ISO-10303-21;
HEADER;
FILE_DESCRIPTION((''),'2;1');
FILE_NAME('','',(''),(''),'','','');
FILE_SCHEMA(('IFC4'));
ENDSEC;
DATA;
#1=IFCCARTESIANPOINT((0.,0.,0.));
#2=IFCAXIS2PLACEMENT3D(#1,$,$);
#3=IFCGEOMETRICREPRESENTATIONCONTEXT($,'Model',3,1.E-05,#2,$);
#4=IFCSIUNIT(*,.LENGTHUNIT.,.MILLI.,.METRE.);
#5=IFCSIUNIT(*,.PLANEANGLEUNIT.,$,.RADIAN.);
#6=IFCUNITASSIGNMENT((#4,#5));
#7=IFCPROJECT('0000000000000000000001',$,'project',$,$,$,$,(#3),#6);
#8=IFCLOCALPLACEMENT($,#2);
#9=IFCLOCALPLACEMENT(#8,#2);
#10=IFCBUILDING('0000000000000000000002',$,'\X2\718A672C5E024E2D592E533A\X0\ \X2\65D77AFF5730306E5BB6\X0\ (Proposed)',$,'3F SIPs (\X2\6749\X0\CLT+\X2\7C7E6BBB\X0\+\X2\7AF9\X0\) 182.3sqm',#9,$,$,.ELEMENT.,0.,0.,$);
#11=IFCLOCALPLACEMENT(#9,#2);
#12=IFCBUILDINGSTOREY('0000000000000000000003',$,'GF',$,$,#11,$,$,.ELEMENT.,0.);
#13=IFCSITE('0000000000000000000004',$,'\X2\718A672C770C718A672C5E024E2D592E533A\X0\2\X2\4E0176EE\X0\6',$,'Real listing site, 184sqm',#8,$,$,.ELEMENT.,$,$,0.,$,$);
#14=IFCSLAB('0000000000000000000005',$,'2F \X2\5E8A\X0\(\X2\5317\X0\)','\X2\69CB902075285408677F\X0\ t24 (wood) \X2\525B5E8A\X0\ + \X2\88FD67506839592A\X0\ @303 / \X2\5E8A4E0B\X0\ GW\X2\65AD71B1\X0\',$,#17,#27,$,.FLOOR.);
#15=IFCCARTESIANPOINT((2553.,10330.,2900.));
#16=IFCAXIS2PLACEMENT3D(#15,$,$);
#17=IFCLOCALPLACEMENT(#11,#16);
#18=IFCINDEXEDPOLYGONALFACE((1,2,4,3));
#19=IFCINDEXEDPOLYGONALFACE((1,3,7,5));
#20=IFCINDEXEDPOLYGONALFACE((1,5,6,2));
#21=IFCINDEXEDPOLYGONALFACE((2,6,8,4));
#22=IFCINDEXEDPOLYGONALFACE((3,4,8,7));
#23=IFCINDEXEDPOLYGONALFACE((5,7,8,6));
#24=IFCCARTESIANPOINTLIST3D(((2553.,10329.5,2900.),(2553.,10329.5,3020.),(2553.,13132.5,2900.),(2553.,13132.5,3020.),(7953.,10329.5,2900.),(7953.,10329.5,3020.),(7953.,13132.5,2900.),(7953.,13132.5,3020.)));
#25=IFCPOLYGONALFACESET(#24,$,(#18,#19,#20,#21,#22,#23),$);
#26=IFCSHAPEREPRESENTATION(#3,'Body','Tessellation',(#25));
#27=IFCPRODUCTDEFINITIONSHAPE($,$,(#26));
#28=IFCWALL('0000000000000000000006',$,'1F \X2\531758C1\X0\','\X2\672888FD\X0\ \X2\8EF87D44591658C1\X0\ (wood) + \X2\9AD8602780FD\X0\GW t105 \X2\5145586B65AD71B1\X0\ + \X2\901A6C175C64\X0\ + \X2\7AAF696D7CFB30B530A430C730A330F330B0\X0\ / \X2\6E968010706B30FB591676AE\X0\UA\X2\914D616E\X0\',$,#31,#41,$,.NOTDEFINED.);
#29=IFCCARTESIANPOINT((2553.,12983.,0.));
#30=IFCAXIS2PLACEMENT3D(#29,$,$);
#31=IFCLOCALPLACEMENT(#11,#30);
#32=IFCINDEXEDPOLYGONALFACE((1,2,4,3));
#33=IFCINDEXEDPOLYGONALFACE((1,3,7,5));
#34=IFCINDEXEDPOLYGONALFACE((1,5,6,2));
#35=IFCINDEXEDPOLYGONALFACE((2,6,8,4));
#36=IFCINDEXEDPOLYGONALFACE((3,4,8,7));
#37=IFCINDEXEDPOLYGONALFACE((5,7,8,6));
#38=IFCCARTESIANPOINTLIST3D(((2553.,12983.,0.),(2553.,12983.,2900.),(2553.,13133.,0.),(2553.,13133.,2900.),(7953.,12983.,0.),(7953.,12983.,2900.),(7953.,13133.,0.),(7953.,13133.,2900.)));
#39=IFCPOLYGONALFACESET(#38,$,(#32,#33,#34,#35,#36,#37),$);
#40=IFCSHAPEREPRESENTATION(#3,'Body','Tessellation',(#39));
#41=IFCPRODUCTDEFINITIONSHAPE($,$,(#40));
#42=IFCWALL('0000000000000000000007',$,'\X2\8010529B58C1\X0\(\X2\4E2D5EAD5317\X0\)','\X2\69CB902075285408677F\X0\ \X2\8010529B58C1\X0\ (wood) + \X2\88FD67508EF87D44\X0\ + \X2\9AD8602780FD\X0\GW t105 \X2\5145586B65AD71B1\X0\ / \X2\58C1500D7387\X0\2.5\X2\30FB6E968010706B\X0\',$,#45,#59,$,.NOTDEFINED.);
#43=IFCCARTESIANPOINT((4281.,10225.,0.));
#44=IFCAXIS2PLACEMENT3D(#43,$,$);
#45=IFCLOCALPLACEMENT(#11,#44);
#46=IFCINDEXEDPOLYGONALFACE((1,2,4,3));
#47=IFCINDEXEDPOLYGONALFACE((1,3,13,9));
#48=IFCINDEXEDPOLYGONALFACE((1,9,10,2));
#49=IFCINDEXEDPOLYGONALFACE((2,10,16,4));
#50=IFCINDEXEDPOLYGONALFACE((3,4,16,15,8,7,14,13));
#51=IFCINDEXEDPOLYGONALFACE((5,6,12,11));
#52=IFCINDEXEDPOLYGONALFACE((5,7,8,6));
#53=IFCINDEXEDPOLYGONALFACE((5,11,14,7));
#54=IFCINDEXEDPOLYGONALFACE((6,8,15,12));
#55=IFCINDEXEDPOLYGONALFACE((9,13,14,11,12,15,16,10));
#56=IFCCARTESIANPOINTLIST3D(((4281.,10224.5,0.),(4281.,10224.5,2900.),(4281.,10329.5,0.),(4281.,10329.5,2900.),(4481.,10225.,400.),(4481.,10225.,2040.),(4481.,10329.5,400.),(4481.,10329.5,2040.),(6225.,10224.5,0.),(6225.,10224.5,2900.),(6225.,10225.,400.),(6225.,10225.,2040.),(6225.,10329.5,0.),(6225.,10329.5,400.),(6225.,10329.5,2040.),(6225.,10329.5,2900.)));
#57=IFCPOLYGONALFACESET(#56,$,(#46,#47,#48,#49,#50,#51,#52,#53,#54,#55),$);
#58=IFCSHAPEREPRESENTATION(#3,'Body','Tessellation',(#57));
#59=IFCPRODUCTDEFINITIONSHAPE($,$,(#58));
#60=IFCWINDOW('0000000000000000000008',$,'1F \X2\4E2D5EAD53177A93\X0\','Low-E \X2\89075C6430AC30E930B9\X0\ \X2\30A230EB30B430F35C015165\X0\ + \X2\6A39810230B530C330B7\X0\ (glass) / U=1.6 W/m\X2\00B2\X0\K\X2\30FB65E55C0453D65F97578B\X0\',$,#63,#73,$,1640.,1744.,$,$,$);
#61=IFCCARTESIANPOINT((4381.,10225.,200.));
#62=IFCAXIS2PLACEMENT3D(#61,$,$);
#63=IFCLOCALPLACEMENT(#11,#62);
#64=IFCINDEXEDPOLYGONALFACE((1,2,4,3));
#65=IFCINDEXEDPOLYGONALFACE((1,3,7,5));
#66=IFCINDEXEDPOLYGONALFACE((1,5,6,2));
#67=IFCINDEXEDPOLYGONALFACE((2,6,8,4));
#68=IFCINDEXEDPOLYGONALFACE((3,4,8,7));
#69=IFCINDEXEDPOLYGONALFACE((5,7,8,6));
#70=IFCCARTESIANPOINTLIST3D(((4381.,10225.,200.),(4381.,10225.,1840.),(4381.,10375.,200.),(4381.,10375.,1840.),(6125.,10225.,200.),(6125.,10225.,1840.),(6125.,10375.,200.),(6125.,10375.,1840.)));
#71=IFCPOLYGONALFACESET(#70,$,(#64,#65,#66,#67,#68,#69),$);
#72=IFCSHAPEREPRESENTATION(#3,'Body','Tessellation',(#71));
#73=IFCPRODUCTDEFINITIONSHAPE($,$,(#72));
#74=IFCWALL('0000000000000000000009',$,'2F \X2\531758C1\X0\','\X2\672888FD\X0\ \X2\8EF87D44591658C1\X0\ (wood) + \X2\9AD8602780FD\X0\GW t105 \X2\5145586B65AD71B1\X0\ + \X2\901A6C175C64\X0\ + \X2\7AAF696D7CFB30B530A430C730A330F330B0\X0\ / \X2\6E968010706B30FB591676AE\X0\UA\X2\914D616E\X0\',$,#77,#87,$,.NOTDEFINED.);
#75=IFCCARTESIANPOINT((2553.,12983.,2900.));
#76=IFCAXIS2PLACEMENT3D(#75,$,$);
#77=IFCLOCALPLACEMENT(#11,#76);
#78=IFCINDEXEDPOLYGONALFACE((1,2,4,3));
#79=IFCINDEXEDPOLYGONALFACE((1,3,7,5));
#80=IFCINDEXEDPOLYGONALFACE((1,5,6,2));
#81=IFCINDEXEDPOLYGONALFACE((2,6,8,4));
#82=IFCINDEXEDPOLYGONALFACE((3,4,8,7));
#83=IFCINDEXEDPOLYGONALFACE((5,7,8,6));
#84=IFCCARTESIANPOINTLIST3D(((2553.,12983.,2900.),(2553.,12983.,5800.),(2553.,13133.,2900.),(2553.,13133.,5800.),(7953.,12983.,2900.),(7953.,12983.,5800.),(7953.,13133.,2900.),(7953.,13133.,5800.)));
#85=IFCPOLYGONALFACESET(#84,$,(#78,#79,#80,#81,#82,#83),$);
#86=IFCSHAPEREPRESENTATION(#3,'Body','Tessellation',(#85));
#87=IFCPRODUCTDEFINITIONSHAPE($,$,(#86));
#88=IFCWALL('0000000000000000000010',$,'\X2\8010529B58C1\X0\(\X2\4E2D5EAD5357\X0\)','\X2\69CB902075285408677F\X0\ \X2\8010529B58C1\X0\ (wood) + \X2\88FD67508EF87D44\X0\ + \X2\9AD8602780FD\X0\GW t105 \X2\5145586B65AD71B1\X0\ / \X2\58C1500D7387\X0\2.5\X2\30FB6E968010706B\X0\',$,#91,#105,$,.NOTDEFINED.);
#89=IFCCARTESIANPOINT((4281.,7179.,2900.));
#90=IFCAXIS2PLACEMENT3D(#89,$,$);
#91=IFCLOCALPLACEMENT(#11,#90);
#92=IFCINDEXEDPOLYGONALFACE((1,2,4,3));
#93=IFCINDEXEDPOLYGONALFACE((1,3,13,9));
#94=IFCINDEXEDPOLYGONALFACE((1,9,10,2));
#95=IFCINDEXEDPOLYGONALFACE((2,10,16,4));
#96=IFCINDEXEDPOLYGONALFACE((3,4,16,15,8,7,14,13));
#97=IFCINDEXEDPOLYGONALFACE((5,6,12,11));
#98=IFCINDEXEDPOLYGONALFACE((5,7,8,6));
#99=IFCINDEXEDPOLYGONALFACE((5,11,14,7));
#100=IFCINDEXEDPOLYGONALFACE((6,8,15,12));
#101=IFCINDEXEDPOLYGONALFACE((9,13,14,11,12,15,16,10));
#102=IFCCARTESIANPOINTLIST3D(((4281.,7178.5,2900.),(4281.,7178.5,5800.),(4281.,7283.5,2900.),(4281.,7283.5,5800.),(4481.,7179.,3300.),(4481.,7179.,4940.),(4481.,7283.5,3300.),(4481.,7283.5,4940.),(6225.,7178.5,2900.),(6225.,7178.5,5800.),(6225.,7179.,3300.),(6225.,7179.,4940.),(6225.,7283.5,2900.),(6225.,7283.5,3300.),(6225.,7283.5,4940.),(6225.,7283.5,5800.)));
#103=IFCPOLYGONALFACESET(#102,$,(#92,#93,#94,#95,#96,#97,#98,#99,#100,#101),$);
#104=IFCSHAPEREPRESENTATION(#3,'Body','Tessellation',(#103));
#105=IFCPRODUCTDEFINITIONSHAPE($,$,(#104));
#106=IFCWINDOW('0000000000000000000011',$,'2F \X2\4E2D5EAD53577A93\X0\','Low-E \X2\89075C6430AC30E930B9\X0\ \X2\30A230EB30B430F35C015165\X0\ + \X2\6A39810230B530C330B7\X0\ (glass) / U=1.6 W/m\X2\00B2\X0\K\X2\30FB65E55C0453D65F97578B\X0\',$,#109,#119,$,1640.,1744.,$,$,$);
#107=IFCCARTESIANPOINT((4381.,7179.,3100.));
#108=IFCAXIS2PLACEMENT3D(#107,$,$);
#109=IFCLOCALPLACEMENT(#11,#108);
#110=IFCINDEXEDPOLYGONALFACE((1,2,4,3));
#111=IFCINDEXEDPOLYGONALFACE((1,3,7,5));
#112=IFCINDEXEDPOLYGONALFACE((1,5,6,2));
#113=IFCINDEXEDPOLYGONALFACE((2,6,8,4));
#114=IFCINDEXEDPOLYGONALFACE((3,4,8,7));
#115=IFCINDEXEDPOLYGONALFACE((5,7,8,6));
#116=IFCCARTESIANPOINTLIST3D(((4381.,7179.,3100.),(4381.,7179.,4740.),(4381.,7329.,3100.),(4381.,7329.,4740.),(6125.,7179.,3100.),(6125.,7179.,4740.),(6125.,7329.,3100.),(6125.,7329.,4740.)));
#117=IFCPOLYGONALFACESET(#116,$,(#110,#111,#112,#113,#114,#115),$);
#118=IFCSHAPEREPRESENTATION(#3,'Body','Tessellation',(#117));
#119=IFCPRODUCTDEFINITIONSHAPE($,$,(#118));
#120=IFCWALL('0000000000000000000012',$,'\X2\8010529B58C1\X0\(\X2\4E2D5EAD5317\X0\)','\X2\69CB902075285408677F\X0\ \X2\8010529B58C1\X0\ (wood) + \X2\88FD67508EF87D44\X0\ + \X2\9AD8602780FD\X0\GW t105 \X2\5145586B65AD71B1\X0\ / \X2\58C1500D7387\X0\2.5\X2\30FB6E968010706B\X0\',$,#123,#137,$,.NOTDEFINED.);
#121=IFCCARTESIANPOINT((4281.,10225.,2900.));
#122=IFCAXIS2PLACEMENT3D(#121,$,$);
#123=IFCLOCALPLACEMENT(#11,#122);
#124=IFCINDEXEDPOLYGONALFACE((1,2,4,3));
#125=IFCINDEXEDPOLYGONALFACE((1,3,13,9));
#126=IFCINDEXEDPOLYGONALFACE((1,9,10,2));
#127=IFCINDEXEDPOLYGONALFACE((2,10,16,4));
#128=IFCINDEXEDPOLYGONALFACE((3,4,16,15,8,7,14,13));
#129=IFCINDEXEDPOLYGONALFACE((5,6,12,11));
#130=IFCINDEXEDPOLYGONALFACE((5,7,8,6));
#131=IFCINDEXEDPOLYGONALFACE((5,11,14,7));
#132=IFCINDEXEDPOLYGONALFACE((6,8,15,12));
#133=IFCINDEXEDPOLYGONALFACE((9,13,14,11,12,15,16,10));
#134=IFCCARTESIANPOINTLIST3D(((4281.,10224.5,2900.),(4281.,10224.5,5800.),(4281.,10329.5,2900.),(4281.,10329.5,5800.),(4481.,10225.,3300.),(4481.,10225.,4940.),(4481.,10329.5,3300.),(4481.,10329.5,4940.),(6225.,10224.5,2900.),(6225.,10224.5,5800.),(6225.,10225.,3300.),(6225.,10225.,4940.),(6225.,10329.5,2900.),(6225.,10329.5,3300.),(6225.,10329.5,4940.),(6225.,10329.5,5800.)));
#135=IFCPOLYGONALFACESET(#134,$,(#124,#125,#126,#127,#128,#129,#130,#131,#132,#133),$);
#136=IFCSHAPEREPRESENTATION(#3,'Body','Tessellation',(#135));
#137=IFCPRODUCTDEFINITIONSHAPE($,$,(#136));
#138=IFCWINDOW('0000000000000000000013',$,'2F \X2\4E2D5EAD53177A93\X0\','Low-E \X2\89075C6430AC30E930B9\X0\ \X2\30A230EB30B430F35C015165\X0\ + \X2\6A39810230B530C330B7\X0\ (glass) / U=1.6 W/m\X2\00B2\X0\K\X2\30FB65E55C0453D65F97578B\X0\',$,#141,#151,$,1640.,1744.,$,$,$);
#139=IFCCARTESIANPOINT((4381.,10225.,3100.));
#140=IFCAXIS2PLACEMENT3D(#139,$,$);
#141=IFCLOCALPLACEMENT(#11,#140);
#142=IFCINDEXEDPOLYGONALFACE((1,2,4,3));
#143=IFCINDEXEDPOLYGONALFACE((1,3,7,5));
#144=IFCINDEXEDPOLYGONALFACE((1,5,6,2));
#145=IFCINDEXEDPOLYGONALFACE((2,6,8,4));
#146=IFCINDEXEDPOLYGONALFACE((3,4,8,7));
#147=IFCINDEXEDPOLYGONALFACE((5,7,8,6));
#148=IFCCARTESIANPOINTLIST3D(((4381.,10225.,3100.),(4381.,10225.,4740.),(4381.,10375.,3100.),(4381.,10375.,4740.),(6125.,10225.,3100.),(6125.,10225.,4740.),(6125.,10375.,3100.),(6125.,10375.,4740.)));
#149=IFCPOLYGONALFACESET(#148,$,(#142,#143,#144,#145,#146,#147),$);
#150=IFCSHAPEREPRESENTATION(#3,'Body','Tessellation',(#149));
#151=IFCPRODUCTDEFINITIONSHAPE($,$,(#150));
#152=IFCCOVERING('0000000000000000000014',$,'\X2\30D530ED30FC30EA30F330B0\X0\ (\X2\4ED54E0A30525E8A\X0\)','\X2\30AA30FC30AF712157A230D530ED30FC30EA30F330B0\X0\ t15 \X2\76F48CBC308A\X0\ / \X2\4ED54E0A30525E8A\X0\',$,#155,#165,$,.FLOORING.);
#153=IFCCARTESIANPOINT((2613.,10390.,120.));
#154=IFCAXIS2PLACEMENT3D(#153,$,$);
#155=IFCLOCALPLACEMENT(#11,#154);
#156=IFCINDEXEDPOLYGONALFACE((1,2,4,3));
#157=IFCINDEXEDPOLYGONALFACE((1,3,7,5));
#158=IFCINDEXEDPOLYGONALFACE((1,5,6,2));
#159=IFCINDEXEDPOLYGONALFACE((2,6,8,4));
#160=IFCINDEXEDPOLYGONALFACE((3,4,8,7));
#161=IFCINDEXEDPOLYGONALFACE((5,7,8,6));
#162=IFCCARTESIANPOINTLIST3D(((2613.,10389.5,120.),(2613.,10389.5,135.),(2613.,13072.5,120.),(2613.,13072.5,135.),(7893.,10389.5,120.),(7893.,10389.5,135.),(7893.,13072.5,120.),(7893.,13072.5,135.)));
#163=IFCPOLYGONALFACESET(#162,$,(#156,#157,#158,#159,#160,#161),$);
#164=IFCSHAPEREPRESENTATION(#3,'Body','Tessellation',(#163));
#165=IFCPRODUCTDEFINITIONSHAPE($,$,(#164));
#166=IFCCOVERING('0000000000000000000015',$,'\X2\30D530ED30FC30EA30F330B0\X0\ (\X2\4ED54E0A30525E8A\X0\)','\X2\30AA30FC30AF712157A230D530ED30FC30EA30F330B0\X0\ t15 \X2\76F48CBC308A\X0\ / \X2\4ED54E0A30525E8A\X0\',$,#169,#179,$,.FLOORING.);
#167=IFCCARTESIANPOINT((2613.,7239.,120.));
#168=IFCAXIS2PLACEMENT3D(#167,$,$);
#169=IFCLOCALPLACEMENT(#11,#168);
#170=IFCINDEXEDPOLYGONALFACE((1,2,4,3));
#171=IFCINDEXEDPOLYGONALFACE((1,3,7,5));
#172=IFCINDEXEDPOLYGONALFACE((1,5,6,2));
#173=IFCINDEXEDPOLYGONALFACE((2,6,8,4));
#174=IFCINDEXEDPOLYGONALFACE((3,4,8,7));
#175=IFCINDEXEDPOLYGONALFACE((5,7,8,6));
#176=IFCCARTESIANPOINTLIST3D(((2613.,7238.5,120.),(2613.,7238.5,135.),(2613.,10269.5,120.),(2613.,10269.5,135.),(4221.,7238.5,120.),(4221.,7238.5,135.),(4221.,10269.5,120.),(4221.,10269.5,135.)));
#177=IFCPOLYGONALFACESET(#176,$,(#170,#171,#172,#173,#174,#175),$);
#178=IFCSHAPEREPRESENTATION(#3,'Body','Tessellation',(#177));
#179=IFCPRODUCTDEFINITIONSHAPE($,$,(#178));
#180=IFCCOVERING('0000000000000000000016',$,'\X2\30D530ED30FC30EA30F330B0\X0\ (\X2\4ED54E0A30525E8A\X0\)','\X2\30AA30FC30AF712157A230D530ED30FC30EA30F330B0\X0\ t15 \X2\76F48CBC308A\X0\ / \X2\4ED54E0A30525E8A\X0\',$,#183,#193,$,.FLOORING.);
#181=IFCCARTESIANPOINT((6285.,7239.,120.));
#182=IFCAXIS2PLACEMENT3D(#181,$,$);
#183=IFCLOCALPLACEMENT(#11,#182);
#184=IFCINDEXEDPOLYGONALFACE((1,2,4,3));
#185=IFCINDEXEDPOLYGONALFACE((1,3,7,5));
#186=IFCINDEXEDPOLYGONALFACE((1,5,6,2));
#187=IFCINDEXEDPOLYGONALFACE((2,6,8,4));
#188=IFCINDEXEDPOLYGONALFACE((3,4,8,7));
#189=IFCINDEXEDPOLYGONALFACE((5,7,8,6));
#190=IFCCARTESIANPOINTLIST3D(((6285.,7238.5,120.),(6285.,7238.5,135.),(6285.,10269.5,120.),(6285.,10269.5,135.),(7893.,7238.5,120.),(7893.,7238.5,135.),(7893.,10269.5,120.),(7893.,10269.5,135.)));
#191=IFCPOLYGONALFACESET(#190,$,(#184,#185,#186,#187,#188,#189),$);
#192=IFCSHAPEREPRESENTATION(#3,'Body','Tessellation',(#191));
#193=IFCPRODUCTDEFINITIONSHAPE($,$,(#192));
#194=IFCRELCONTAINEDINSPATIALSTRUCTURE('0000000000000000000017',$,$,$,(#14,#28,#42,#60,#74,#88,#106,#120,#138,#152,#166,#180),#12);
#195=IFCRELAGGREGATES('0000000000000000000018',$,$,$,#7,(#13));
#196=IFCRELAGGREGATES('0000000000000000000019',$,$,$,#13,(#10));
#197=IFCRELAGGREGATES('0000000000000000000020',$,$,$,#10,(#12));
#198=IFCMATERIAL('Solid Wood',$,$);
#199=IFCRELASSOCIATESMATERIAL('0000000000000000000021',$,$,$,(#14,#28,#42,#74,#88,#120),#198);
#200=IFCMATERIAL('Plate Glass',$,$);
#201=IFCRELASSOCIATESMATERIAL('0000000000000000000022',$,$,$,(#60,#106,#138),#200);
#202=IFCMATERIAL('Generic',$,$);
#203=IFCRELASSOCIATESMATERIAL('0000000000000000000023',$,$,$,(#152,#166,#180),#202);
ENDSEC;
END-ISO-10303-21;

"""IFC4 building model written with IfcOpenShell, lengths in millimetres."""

from ifc_helpers import new_model, si_unit, frame, frame_2d, origin, place, context, project, spatial, rectangle, extrude, material, element, fill, save


model = new_model("IFC4")

# Units and contexts
model_context = context("Model", 3, precision=1e-05, world=origin())
ifc_project = project(units=[si_unit("LENGTHUNIT", "METRE", prefix="MILLI"), si_unit("PLANEANGLEUNIT", "RADIAN")], contexts=[model_context])

# Site, building, storey
site_placement = place(None, origin())
site = spatial("IfcSite", under=ifc_project, at=site_placement, Name="熊本県熊本市中央区2丁目6", ObjectType="Real listing site, 184sqm", CompositionType="ELEMENT", RefElevation=0.0)
building_placement = place(site_placement, origin())
building = spatial("IfcBuilding", under=site, at=building_placement, Name="熊本市中央区 旗竿地の家 (Proposed)", ObjectType="3F SIPs (杉CLT+籾殻+竹) 182.3sqm", CompositionType="ELEMENT", ElevationOfRefHeight=0.0, ElevationOfTerrain=0.0)
storey_placement = place(building_placement, origin())
storey = spatial("IfcBuildingStorey", under=building, at=storey_placement, Name="GF", CompositionType="ELEMENT", Elevation=0.0)

# Slab
ifc_material_1 = material(Name="Solid Wood")
slab_1_placement = place(storey_placement, frame((2553.0, 10330.0, 2900.0)))
element("IfcSlab", 1, at=slab_1_placement, inside=storey, material=ifc_material_1, Name="2F 床(北)", Description="構造用合板 t24 (wood) 剛床 + 製材根太 @303 / 床下 GW断熱", PredefinedType="FLOOR", context=model_context, shape_type="SweptSolid", body=[
    extrude(rectangle(XDim=5400.0, YDim=2803.0, at=frame_2d((2700.0, 1401.0))), frame((2553.0, 10330.0, 2900.0)), (0.0, 0.0, 1.0), 120.0),
])

# Wall
wall_1_placement = place(storey_placement, frame((2553.0, 12983.0, 0.0)))
element("IfcWall", 2, at=wall_1_placement, inside=storey, material=ifc_material_1, Name="1F 北壁", Description="木製 軸組外壁 (wood) + 高性能GW t105 充填断熱 + 通気層 + 窯業系サイディング / 準耐火・外皮UA配慮", PredefinedType="NOTDEFINED", context=model_context, shape_type="SweptSolid", body=[
    extrude(rectangle(XDim=5400.0, YDim=150.0, at=frame_2d((2700.0, 75.0))), frame((2553.0, 12983.0, 0.0)), (0.0, 0.0, 1.0), 2900.0),
])

# Wall, opening, window
wall_2_placement = place(storey_placement, frame((4281.0, 10225.0, 0.0)))
wall_2 = element("IfcWall", 3, at=wall_2_placement, inside=storey, material=ifc_material_1, Name="耐力壁(中庭北)", Description="構造用合板 耐力壁 (wood) + 製材軸組 + 高性能GW t105 充填断熱 / 壁倍率2.5・準耐火", PredefinedType="NOTDEFINED", context=model_context, shape_type="SweptSolid", body=[
    extrude(rectangle(XDim=1944.0, YDim=105.0, at=frame_2d((972.0, 52.0))), frame((4281.0, 10225.0, 0.0)), (0.0, 0.0, 1.0), 2900.0),
])
opening_1_placement = place(storey_placement, frame((4381.0, 10225.0, 200.0)))
opening_1 = element("IfcOpeningElement", 4, at=opening_1_placement, cuts=wall_2, PredefinedType="NOTDEFINED", context=model_context, shape_type="SweptSolid", body=[
    extrude(rectangle(XDim=1744.0, YDim=150.0, at=frame_2d((872.0, 75.0))), frame((4381.0, 10225.0, 200.0)), (0.0, 0.0, 1.0), 1640.0),
])
ifc_material_2 = material(Name="Plate Glass")
window_1_placement = place(storey_placement, frame((4381.0, 10225.0, 200.0)))
window_1 = element("IfcWindow", 5, at=window_1_placement, inside=storey, material=ifc_material_2, Name="1F 中庭北窓", Description="Low-E 複層ガラス アルゴン封入 + 樹脂サッシ (glass) / U=1.6 W/m²K・日射取得型", OverallHeight=1640.0, OverallWidth=1744.0, context=model_context, shape_type="SweptSolid", body=[
    extrude(rectangle(XDim=1744.0, YDim=150.0, at=frame_2d((872.0, 75.0))), frame((4381.0, 10225.0, 200.0)), (0.0, 0.0, 1.0), 1640.0),
])
fill(opening_1, window_1)

# Wall
wall_3_placement = place(storey_placement, frame((2553.0, 12983.0, 2900.0)))
element("IfcWall", 6, at=wall_3_placement, inside=storey, material=ifc_material_1, Name="2F 北壁", Description="木製 軸組外壁 (wood) + 高性能GW t105 充填断熱 + 通気層 + 窯業系サイディング / 準耐火・外皮UA配慮", PredefinedType="NOTDEFINED", context=model_context, shape_type="SweptSolid", body=[
    extrude(rectangle(XDim=5400.0, YDim=150.0, at=frame_2d((2700.0, 75.0))), frame((2553.0, 12983.0, 2900.0)), (0.0, 0.0, 1.0), 2900.0),
])

# Walls, openings, windows
wall_4_placement = place(storey_placement, frame((4281.0, 7179.0, 2900.0)))
wall_4 = element("IfcWall", 7, at=wall_4_placement, inside=storey, material=ifc_material_1, Name="耐力壁(中庭南)", Description="構造用合板 耐力壁 (wood) + 製材軸組 + 高性能GW t105 充填断熱 / 壁倍率2.5・準耐火", PredefinedType="NOTDEFINED", context=model_context, shape_type="SweptSolid", body=[
    extrude(rectangle(XDim=1944.0, YDim=105.0, at=frame_2d((972.0, 52.0))), frame((4281.0, 7179.0, 2900.0)), (0.0, 0.0, 1.0), 2900.0),
])
opening_2_placement = place(storey_placement, frame((4381.0, 7179.0, 3100.0)))
opening_2 = element("IfcOpeningElement", 8, at=opening_2_placement, cuts=wall_4, PredefinedType="NOTDEFINED", context=model_context, shape_type="SweptSolid", body=[
    extrude(rectangle(XDim=1744.0, YDim=150.0, at=frame_2d((872.0, 75.0))), frame((4381.0, 7179.0, 3100.0)), (0.0, 0.0, 1.0), 1640.0),
])
window_2_placement = place(storey_placement, frame((4381.0, 7179.0, 3100.0)))
window_2 = element("IfcWindow", 9, at=window_2_placement, inside=storey, material=ifc_material_2, Name="2F 中庭南窓", Description="Low-E 複層ガラス アルゴン封入 + 樹脂サッシ (glass) / U=1.6 W/m²K・日射取得型", OverallHeight=1640.0, OverallWidth=1744.0, context=model_context, shape_type="SweptSolid", body=[
    extrude(rectangle(XDim=1744.0, YDim=150.0, at=frame_2d((872.0, 75.0))), frame((4381.0, 7179.0, 3100.0)), (0.0, 0.0, 1.0), 1640.0),
])
fill(opening_2, window_2)
wall_5_placement = place(storey_placement, frame((4281.0, 10225.0, 2900.0)))
wall_5 = element("IfcWall", 10, at=wall_5_placement, inside=storey, material=ifc_material_1, Name="耐力壁(中庭北)", Description="構造用合板 耐力壁 (wood) + 製材軸組 + 高性能GW t105 充填断熱 / 壁倍率2.5・準耐火", PredefinedType="NOTDEFINED", context=model_context, shape_type="SweptSolid", body=[
    extrude(rectangle(XDim=1944.0, YDim=105.0, at=frame_2d((972.0, 52.0))), frame((4281.0, 10225.0, 2900.0)), (0.0, 0.0, 1.0), 2900.0),
])
opening_3_placement = place(storey_placement, frame((4381.0, 10225.0, 3100.0)))
opening_3 = element("IfcOpeningElement", 11, at=opening_3_placement, cuts=wall_5, PredefinedType="NOTDEFINED", context=model_context, shape_type="SweptSolid", body=[
    extrude(rectangle(XDim=1744.0, YDim=150.0, at=frame_2d((872.0, 75.0))), frame((4381.0, 10225.0, 3100.0)), (0.0, 0.0, 1.0), 1640.0),
])
window_3_placement = place(storey_placement, frame((4381.0, 10225.0, 3100.0)))
window_3 = element("IfcWindow", 12, at=window_3_placement, inside=storey, material=ifc_material_2, Name="2F 中庭北窓", Description="Low-E 複層ガラス アルゴン封入 + 樹脂サッシ (glass) / U=1.6 W/m²K・日射取得型", OverallHeight=1640.0, OverallWidth=1744.0, context=model_context, shape_type="SweptSolid", body=[
    extrude(rectangle(XDim=1744.0, YDim=150.0, at=frame_2d((872.0, 75.0))), frame((4381.0, 10225.0, 3100.0)), (0.0, 0.0, 1.0), 1640.0),
])
fill(opening_3, window_3)

# Coverings
ifc_material_3 = material(Name="Generic")
covering_1_placement = place(storey_placement, frame((2613.0, 10390.0, 120.0)))
element("IfcCovering", 13, at=covering_1_placement, inside=storey, material=ifc_material_3, Name="フローリング (仕上げ床)", Description="オーク無垢フローリング t15 直貼り / 仕上げ床", PredefinedType="FLOORING", context=model_context, shape_type="SweptSolid", body=[
    extrude(rectangle(XDim=5280.0, YDim=2683.0, at=frame_2d((2640.0, 1341.0))), frame((2613.0, 10390.0, 120.0)), (0.0, 0.0, 1.0), 15.0),
])
covering_2_placement = place(storey_placement, frame((2613.0, 7239.0, 120.0)))
element("IfcCovering", 14, at=covering_2_placement, inside=storey, material=ifc_material_3, Name="フローリング (仕上げ床)", Description="オーク無垢フローリング t15 直貼り / 仕上げ床", PredefinedType="FLOORING", context=model_context, shape_type="SweptSolid", body=[
    extrude(rectangle(XDim=1608.0, YDim=3031.0, at=frame_2d((804.0, 1515.0))), frame((2613.0, 7239.0, 120.0)), (0.0, 0.0, 1.0), 15.0),
])
covering_3_placement = place(storey_placement, frame((6285.0, 7239.0, 120.0)))
element("IfcCovering", 15, at=covering_3_placement, inside=storey, material=ifc_material_3, Name="フローリング (仕上げ床)", Description="オーク無垢フローリング t15 直貼り / 仕上げ床", PredefinedType="FLOORING", context=model_context, shape_type="SweptSolid", body=[
    extrude(rectangle(XDim=1608.0, YDim=3031.0, at=frame_2d((804.0, 1515.0))), frame((6285.0, 7239.0, 120.0)), (0.0, 0.0, 1.0), 15.0),
])

save(model, "model.ifc")
